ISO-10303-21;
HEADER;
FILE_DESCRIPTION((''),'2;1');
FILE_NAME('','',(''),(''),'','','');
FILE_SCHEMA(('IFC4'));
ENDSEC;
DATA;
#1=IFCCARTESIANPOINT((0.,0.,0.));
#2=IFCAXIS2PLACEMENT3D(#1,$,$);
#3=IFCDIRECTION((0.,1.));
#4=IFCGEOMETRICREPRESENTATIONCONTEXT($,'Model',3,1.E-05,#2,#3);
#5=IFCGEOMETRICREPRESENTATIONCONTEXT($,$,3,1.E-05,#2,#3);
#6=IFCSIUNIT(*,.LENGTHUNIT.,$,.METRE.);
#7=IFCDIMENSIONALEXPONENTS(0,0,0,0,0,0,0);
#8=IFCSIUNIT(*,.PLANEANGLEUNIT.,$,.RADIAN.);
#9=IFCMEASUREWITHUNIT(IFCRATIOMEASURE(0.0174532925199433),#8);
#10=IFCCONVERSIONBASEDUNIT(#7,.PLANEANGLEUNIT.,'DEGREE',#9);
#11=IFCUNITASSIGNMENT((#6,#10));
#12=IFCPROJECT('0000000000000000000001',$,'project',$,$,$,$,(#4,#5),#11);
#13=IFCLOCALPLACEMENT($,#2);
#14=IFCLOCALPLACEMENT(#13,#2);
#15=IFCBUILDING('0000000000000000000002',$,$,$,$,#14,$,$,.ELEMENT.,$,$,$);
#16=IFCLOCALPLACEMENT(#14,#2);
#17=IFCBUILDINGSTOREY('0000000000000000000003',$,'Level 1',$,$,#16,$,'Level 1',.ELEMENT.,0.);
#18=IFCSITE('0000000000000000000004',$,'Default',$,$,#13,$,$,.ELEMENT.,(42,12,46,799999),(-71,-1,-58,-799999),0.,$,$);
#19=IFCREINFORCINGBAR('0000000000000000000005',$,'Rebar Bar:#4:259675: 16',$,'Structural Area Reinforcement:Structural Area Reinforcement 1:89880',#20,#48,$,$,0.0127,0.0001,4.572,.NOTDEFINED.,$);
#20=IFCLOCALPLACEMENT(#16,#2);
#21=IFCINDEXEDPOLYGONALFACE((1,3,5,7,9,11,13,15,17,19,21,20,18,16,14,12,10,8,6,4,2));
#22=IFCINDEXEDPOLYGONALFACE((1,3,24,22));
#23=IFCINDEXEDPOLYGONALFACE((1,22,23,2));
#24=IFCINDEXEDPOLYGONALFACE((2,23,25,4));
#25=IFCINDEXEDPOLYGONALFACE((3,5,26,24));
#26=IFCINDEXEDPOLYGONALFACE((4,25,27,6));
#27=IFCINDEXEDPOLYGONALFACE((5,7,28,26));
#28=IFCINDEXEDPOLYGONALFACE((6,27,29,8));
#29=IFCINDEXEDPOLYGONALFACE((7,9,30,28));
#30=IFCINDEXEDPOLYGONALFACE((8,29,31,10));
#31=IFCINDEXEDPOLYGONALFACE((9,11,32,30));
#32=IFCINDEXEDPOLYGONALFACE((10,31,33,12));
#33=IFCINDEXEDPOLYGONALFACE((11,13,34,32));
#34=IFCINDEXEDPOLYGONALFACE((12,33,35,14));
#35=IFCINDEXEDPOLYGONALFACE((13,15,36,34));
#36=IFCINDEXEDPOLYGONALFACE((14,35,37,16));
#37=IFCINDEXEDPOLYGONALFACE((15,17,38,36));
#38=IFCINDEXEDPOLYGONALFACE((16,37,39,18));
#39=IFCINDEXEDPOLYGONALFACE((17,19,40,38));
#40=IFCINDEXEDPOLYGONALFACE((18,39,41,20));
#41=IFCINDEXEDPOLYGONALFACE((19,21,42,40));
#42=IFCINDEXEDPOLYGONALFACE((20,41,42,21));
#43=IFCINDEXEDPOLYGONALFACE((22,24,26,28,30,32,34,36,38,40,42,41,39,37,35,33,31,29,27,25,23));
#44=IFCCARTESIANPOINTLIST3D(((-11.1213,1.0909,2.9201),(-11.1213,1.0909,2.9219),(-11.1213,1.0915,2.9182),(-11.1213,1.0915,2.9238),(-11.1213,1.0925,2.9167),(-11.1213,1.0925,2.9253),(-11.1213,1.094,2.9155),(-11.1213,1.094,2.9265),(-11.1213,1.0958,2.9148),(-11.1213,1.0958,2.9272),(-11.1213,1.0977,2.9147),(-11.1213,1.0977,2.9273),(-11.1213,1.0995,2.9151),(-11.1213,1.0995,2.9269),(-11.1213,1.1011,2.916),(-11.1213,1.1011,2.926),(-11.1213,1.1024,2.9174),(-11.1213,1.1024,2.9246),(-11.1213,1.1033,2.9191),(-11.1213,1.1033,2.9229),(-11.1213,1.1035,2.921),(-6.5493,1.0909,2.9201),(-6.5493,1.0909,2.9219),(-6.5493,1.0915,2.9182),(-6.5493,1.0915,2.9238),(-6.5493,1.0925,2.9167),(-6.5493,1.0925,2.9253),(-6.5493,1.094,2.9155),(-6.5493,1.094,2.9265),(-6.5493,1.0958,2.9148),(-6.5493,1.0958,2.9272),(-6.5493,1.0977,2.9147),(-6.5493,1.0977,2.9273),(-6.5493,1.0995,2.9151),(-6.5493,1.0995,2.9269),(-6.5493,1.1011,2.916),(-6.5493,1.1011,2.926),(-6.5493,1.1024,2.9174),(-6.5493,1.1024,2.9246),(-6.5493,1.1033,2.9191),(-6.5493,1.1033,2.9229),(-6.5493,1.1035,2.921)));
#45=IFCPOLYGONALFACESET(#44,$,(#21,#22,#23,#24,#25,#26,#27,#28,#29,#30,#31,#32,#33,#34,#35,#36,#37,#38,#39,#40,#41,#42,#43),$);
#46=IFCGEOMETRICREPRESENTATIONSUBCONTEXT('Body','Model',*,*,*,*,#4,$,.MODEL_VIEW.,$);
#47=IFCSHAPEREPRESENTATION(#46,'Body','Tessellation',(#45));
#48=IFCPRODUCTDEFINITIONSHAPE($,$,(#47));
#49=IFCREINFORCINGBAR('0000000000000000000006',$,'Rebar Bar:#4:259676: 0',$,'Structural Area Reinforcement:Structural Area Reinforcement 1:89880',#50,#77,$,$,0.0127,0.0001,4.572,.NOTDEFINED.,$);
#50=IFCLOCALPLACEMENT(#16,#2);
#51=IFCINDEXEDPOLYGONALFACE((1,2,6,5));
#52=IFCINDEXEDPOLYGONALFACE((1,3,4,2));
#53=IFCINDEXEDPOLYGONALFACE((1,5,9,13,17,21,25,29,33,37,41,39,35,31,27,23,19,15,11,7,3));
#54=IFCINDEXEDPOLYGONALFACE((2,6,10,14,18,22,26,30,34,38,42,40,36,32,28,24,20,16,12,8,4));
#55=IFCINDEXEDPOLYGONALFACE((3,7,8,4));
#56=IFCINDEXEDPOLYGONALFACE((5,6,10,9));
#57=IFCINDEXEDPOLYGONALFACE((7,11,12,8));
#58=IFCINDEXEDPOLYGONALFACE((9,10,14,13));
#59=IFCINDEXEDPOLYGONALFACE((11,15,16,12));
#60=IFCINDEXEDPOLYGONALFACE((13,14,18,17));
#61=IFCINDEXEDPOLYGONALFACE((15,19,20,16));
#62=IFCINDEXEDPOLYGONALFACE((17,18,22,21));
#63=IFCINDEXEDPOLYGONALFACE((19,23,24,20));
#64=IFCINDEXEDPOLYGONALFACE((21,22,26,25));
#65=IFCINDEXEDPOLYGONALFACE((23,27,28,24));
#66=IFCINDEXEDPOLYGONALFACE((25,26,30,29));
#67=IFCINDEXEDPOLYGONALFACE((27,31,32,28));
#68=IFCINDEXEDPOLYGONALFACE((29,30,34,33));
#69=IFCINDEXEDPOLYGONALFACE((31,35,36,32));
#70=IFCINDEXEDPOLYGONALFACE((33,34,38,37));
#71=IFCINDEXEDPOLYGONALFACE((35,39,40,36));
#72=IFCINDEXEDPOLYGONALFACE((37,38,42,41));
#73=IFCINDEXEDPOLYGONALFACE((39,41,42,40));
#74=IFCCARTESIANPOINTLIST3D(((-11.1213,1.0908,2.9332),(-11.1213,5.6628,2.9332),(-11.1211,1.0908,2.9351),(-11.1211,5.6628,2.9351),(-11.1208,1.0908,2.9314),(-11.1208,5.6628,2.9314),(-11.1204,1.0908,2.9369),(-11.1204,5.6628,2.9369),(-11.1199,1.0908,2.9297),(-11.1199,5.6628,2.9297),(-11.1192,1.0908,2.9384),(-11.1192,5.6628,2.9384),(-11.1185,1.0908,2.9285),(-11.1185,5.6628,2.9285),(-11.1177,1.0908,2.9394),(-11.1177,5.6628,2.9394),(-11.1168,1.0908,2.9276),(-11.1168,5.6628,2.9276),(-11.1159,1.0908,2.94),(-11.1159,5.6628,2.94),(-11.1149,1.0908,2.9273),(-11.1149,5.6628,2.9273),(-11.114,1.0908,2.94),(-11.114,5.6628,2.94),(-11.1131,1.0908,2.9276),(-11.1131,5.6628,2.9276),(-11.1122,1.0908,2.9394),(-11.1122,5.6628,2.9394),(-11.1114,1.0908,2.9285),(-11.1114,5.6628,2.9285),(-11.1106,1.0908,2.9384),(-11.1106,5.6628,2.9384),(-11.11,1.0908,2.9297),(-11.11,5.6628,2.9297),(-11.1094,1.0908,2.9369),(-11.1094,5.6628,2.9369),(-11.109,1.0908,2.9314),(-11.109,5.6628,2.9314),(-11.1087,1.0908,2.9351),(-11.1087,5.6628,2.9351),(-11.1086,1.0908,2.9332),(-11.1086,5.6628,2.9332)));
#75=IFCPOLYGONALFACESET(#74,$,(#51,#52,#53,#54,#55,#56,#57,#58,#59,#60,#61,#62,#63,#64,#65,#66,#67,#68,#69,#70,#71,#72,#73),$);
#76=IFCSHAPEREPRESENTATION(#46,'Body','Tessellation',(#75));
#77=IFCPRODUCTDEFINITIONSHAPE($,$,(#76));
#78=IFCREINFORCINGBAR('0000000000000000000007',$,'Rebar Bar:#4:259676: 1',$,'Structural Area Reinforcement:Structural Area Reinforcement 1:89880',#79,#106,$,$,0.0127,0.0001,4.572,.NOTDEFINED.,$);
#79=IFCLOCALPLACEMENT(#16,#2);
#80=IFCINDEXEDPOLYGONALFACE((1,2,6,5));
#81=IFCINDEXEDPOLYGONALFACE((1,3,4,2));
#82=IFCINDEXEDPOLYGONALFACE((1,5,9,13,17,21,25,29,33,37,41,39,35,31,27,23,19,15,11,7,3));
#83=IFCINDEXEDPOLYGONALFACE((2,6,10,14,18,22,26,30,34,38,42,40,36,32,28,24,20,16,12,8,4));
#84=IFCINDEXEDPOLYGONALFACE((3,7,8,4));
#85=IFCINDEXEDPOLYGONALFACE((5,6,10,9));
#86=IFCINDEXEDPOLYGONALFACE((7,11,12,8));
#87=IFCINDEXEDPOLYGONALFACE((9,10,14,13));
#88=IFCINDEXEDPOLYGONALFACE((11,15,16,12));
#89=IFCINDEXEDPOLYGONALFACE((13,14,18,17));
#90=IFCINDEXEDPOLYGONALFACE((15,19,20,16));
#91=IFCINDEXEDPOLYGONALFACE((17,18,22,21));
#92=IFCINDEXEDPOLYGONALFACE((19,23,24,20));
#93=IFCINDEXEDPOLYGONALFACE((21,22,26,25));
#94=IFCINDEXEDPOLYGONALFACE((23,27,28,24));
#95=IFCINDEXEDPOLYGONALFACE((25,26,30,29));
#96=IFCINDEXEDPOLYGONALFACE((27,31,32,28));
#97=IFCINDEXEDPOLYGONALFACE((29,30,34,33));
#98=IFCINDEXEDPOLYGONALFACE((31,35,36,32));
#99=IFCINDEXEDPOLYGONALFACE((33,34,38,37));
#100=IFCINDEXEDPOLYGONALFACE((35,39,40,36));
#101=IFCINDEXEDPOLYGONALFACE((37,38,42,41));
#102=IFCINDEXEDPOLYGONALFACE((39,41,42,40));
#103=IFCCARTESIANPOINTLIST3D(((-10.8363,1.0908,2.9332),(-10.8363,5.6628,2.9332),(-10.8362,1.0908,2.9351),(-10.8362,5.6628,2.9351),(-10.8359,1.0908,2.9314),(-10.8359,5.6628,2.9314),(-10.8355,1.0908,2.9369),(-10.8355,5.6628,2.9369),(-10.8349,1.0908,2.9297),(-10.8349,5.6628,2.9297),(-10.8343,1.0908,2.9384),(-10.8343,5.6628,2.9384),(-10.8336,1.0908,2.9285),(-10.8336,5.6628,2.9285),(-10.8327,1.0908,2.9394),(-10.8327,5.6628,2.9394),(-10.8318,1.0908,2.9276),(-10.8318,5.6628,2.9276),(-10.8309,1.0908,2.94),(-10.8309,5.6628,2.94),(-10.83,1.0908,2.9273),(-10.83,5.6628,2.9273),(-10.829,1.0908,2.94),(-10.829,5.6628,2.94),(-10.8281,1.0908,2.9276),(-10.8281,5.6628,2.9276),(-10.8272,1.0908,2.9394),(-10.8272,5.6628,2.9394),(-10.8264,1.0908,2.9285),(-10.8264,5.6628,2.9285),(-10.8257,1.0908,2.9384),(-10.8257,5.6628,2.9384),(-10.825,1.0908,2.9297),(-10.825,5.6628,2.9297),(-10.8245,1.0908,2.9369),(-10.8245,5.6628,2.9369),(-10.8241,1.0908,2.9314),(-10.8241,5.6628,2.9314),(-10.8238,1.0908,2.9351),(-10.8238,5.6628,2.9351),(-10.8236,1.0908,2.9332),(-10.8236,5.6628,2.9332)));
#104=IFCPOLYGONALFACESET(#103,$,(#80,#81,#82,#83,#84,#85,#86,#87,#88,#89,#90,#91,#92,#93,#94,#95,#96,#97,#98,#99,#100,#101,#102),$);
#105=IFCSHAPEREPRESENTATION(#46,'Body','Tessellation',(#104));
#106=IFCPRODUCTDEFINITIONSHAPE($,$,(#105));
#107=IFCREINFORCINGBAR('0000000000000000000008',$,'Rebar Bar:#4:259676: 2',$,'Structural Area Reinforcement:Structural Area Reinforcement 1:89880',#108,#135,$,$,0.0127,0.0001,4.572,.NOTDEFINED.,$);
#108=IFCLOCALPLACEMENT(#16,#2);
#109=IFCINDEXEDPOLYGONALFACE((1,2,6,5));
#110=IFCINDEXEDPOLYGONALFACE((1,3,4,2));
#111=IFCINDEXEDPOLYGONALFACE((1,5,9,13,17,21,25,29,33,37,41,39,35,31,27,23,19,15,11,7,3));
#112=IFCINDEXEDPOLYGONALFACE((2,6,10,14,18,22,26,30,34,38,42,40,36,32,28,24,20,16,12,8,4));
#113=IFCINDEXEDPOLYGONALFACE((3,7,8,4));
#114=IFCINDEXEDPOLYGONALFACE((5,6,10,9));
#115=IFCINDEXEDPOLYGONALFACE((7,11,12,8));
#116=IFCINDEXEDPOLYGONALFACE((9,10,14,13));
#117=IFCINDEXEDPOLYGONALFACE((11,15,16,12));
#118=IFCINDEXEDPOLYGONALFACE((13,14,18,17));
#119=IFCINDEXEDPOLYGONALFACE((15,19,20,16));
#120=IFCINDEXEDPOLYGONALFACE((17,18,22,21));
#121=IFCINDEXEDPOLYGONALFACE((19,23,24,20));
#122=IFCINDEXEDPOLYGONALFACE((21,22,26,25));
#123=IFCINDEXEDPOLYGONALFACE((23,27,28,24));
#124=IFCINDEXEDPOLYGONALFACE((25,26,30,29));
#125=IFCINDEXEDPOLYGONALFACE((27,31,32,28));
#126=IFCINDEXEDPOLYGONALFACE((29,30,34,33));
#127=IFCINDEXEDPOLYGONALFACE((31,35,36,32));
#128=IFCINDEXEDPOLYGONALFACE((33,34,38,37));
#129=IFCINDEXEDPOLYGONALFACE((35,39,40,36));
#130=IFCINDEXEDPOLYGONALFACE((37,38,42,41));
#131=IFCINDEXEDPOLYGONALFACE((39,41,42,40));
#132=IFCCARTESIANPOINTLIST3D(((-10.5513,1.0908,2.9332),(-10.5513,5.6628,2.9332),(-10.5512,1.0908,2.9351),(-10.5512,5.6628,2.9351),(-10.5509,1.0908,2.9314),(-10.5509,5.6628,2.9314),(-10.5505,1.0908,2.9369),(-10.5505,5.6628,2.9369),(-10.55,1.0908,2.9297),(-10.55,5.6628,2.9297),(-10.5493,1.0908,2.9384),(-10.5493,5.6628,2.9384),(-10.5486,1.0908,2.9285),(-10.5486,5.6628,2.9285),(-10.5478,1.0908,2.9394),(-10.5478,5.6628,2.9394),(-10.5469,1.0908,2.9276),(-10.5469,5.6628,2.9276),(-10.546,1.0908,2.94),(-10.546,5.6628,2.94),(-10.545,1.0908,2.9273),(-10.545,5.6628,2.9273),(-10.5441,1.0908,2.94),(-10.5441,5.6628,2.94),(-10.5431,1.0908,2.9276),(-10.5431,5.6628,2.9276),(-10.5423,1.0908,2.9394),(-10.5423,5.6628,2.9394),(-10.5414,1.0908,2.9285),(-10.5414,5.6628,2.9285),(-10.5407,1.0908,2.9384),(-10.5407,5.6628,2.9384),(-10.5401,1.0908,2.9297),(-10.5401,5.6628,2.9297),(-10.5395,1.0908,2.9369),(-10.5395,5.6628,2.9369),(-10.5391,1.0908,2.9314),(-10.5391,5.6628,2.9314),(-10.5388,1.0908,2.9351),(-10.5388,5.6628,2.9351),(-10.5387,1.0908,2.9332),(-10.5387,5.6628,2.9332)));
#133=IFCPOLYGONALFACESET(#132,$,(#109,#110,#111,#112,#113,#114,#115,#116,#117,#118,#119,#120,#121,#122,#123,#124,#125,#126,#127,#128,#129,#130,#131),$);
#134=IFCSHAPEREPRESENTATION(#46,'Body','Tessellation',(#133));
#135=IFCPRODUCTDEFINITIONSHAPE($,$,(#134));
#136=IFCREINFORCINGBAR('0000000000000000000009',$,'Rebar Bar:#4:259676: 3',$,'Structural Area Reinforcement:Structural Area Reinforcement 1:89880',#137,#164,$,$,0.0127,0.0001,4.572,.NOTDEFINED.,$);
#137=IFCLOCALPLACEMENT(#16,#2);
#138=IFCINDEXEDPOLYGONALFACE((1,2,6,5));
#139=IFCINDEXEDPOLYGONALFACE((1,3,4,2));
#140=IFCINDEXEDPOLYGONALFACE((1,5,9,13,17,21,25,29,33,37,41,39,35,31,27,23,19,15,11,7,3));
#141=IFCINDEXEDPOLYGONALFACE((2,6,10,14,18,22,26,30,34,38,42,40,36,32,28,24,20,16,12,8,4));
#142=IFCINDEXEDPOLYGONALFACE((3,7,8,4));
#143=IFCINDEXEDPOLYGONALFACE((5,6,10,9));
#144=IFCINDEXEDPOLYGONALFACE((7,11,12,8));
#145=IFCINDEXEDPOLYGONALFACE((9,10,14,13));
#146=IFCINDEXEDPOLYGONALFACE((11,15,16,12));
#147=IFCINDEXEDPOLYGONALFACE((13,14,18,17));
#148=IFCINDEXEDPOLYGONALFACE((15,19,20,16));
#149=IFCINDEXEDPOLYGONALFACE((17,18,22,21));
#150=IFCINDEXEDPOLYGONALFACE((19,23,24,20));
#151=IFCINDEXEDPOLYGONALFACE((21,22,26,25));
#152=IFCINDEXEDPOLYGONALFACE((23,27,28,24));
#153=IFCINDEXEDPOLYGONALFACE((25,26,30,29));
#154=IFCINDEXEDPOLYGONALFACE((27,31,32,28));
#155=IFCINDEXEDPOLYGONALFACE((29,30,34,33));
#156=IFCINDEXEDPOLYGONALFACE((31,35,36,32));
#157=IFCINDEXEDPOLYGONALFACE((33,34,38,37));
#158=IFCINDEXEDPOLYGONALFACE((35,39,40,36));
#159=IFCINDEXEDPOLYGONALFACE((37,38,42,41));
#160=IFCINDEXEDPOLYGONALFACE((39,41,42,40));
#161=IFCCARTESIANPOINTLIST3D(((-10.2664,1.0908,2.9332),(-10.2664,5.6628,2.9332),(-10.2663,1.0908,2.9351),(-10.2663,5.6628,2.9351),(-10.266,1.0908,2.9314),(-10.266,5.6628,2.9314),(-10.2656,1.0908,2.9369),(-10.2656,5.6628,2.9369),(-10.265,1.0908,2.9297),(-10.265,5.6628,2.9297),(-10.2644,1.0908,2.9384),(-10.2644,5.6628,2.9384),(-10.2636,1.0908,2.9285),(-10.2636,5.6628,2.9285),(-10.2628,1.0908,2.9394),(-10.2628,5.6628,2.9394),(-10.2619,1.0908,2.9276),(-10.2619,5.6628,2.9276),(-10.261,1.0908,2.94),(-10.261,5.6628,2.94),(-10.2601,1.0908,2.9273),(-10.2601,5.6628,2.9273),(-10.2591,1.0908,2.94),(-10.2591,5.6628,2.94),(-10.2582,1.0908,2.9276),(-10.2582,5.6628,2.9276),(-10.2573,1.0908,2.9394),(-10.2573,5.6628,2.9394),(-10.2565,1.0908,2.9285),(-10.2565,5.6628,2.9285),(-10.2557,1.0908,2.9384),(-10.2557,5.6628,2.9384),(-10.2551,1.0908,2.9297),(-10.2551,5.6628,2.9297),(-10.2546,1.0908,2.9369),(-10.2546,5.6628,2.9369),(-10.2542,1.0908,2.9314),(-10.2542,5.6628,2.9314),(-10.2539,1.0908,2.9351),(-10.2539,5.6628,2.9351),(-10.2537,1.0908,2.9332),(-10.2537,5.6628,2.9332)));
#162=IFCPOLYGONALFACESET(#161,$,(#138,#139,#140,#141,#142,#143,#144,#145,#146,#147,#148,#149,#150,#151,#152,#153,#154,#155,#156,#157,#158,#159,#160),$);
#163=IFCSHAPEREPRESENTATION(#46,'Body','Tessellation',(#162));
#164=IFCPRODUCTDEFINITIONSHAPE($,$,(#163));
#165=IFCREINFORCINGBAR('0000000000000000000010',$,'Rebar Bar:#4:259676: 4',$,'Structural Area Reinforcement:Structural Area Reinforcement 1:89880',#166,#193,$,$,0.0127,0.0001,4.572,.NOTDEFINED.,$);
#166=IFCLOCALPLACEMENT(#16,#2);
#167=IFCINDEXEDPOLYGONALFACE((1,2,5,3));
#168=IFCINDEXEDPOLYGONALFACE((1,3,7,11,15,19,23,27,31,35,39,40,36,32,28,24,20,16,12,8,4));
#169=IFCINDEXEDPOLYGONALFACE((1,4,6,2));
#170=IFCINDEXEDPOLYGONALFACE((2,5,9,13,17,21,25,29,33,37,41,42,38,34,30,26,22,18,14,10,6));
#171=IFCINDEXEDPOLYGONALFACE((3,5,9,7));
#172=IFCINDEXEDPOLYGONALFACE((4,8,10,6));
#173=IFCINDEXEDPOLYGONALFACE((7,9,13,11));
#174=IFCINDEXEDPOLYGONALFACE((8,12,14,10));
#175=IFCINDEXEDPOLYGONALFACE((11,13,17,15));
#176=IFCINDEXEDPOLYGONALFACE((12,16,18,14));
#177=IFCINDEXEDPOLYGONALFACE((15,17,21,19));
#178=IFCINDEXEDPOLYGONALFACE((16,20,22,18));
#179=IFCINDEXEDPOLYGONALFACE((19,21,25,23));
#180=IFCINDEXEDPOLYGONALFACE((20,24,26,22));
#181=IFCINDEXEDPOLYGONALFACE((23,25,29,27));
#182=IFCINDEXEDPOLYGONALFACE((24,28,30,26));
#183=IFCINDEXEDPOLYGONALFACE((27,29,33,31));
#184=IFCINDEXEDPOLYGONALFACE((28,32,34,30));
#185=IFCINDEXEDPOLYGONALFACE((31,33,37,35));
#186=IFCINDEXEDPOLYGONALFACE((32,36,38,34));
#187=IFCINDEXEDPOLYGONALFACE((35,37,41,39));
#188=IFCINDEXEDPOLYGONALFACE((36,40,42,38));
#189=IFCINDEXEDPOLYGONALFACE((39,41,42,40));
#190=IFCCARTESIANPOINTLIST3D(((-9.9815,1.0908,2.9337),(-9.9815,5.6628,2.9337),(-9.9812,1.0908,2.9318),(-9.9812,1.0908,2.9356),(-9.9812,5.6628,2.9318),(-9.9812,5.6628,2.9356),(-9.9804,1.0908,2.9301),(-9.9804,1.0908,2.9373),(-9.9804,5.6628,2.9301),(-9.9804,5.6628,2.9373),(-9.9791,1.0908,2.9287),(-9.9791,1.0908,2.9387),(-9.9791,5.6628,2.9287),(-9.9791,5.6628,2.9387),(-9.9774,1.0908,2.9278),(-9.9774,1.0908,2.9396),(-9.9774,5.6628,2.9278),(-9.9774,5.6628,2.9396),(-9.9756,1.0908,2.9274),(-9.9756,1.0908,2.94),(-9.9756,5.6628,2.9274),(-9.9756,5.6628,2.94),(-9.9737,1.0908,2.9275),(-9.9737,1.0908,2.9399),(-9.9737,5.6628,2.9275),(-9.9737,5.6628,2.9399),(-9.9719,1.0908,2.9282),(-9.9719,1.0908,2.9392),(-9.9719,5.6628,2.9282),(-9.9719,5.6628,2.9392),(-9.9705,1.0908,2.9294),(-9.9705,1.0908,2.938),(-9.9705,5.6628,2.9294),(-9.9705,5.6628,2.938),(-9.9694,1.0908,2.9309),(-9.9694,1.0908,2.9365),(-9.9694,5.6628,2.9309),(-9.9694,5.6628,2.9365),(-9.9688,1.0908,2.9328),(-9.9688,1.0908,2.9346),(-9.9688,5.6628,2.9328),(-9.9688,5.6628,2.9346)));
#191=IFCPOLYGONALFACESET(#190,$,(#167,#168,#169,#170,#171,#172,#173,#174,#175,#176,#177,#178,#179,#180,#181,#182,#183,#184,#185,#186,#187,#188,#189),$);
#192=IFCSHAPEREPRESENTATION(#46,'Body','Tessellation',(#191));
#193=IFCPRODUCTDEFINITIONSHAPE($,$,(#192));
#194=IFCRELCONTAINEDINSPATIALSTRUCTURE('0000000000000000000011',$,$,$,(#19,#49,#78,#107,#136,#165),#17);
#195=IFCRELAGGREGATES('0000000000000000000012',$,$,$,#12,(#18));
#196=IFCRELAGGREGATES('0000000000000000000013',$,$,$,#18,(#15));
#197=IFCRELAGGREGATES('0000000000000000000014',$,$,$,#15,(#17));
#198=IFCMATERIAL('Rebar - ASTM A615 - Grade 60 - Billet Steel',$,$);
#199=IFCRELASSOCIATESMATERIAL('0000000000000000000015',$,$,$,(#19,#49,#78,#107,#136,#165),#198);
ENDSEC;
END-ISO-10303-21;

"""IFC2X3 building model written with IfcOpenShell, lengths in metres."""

from ifc_helpers import new_model, entity, si_unit, converted_unit, direction, origin, place, context, subcontext, project, spatial, material, element, save


model = new_model("IFC2X3")

# Units and contexts
model_context = context("Model", 3, precision=1e-05, world=origin(), true_north=direction((0.0, 1.0)))
context_of_model = context(None, 3, precision=1e-05, world=origin(), true_north=direction((0.0, 1.0)))
body_context = subcontext(model_context, "Body", "Model", "MODEL_VIEW")
ifc_project = project(units=[si_unit("LENGTHUNIT", "METRE"), converted_unit("PLANEANGLEUNIT", "DEGREE", entity("IfcRatioMeasure", 0.0174532925199433), si_unit("PLANEANGLEUNIT", "RADIAN"), dimensions=[0, 0, 0, 0, 0, 0, 0])], contexts=[model_context, context_of_model])

# Site, building, storey
site_placement = place(None, origin())
site = spatial("IfcSite", under=ifc_project, at=site_placement, Name="Default", CompositionType="ELEMENT", RefLatitude=(42, 12, 46, 799999), RefLongitude=(-71, -1, -58, -799999), RefElevation=0.0)
building_placement = place(site_placement, origin())
building = spatial("IfcBuilding", under=site, at=building_placement, CompositionType="ELEMENT")
storey_placement = place(building_placement, origin())
storey = spatial("IfcBuildingStorey", under=building, at=storey_placement, Name="Level 1", LongName="Level 1", CompositionType="ELEMENT", Elevation=0.0)

# Reinforcing bars
ifc_material_1 = material(Name="Rebar - ASTM A615 - Grade 60 - Billet Steel")
reinforcing_bar_1_placement = place(storey_placement, origin())
element("IfcReinforcingBar", 1, at=reinforcing_bar_1_placement, inside=storey, material=ifc_material_1, Name="Rebar Bar:#4:259675: 16", ObjectType="Structural Area Reinforcement:Structural Area Reinforcement 1:89880", BarLength=4.572, BarRole="NOTDEFINED", CrossSectionArea=0.0001, NominalDiameter=0.0127, context=body_context, shape_type="AdvancedSweptSolid", body=[
    entity("IfcSweptDiskSolid", entity("IfcCompositeCurve", [entity("IfcCompositeCurveSegment", "CONTINUOUS", True, entity("IfcPolyline", [entity("IfcCartesianPoint", [-11.1213, 1.0972, 2.921]), entity("IfcCartesianPoint", [-6.5493, 1.0972, 2.921])]))], False), 0.0063, None, 0.0, 1.0),
])
reinforcing_bar_2_placement = place(storey_placement, origin())
element("IfcReinforcingBar", 2, at=reinforcing_bar_2_placement, inside=storey, material=ifc_material_1, Name="Rebar Bar:#4:259676: 0", ObjectType="Structural Area Reinforcement:Structural Area Reinforcement 1:89880", BarLength=4.572, BarRole="NOTDEFINED", CrossSectionArea=0.0001, NominalDiameter=0.0127, context=body_context, shape_type="AdvancedSweptSolid", body=[
    entity("IfcSweptDiskSolid", entity("IfcCompositeCurve", [entity("IfcCompositeCurveSegment", "CONTINUOUS", True, entity("IfcPolyline", [entity("IfcCartesianPoint", [-11.1149, 5.6628, 2.9337]), entity("IfcCartesianPoint", [-11.1149, 1.0908, 2.9337])]))], False), 0.0063, None, 0.0, 1.0),
])
reinforcing_bar_3_placement = place(storey_placement, origin())
element("IfcReinforcingBar", 3, at=reinforcing_bar_3_placement, inside=storey, material=ifc_material_1, Name="Rebar Bar:#4:259676: 1", ObjectType="Structural Area Reinforcement:Structural Area Reinforcement 1:89880", BarLength=4.572, BarRole="NOTDEFINED", CrossSectionArea=0.0001, NominalDiameter=0.0127, context=body_context, shape_type="AdvancedSweptSolid", body=[
    entity("IfcSweptDiskSolid", entity("IfcCompositeCurve", [entity("IfcCompositeCurveSegment", "CONTINUOUS", True, entity("IfcPolyline", [entity("IfcCartesianPoint", [-10.83, 5.6628, 2.9337]), entity("IfcCartesianPoint", [-10.83, 1.0908, 2.9337])]))], False), 0.0063, None, 0.0, 1.0),
])
reinforcing_bar_4_placement = place(storey_placement, origin())
element("IfcReinforcingBar", 4, at=reinforcing_bar_4_placement, inside=storey, material=ifc_material_1, Name="Rebar Bar:#4:259676: 2", ObjectType="Structural Area Reinforcement:Structural Area Reinforcement 1:89880", BarLength=4.572, BarRole="NOTDEFINED", CrossSectionArea=0.0001, NominalDiameter=0.0127, context=body_context, shape_type="AdvancedSweptSolid", body=[
    entity("IfcSweptDiskSolid", entity("IfcCompositeCurve", [entity("IfcCompositeCurveSegment", "CONTINUOUS", True, entity("IfcPolyline", [entity("IfcCartesianPoint", [-10.545, 5.6628, 2.9337]), entity("IfcCartesianPoint", [-10.545, 1.0908, 2.9337])]))], False), 0.0063, None, 0.0, 1.0),
])
reinforcing_bar_5_placement = place(storey_placement, origin())
element("IfcReinforcingBar", 5, at=reinforcing_bar_5_placement, inside=storey, material=ifc_material_1, Name="Rebar Bar:#4:259676: 3", ObjectType="Structural Area Reinforcement:Structural Area Reinforcement 1:89880", BarLength=4.572, BarRole="NOTDEFINED", CrossSectionArea=0.0001, NominalDiameter=0.0127, context=body_context, shape_type="AdvancedSweptSolid", body=[
    entity("IfcSweptDiskSolid", entity("IfcCompositeCurve", [entity("IfcCompositeCurveSegment", "CONTINUOUS", True, entity("IfcPolyline", [entity("IfcCartesianPoint", [-10.2601, 5.6628, 2.9337]), entity("IfcCartesianPoint", [-10.2601, 1.0908, 2.9337])]))], False), 0.0063, None, 0.0, 1.0),
])
reinforcing_bar_6_placement = place(storey_placement, origin())
element("IfcReinforcingBar", 6, at=reinforcing_bar_6_placement, inside=storey, material=ifc_material_1, Name="Rebar Bar:#4:259676: 4", ObjectType="Structural Area Reinforcement:Structural Area Reinforcement 1:89880", BarLength=4.572, BarRole="NOTDEFINED", CrossSectionArea=0.0001, NominalDiameter=0.0127, context=body_context, shape_type="AdvancedSweptSolid", body=[
    entity("IfcSweptDiskSolid", entity("IfcCompositeCurve", [entity("IfcCompositeCurveSegment", "CONTINUOUS", True, entity("IfcPolyline", [entity("IfcCartesianPoint", [-9.9751, 5.6628, 2.9337]), entity("IfcCartesianPoint", [-9.9751, 1.0908, 2.9337])]))], False), 0.0063, None, 0.0, 1.0),
])

save(model, "model.ifc")
